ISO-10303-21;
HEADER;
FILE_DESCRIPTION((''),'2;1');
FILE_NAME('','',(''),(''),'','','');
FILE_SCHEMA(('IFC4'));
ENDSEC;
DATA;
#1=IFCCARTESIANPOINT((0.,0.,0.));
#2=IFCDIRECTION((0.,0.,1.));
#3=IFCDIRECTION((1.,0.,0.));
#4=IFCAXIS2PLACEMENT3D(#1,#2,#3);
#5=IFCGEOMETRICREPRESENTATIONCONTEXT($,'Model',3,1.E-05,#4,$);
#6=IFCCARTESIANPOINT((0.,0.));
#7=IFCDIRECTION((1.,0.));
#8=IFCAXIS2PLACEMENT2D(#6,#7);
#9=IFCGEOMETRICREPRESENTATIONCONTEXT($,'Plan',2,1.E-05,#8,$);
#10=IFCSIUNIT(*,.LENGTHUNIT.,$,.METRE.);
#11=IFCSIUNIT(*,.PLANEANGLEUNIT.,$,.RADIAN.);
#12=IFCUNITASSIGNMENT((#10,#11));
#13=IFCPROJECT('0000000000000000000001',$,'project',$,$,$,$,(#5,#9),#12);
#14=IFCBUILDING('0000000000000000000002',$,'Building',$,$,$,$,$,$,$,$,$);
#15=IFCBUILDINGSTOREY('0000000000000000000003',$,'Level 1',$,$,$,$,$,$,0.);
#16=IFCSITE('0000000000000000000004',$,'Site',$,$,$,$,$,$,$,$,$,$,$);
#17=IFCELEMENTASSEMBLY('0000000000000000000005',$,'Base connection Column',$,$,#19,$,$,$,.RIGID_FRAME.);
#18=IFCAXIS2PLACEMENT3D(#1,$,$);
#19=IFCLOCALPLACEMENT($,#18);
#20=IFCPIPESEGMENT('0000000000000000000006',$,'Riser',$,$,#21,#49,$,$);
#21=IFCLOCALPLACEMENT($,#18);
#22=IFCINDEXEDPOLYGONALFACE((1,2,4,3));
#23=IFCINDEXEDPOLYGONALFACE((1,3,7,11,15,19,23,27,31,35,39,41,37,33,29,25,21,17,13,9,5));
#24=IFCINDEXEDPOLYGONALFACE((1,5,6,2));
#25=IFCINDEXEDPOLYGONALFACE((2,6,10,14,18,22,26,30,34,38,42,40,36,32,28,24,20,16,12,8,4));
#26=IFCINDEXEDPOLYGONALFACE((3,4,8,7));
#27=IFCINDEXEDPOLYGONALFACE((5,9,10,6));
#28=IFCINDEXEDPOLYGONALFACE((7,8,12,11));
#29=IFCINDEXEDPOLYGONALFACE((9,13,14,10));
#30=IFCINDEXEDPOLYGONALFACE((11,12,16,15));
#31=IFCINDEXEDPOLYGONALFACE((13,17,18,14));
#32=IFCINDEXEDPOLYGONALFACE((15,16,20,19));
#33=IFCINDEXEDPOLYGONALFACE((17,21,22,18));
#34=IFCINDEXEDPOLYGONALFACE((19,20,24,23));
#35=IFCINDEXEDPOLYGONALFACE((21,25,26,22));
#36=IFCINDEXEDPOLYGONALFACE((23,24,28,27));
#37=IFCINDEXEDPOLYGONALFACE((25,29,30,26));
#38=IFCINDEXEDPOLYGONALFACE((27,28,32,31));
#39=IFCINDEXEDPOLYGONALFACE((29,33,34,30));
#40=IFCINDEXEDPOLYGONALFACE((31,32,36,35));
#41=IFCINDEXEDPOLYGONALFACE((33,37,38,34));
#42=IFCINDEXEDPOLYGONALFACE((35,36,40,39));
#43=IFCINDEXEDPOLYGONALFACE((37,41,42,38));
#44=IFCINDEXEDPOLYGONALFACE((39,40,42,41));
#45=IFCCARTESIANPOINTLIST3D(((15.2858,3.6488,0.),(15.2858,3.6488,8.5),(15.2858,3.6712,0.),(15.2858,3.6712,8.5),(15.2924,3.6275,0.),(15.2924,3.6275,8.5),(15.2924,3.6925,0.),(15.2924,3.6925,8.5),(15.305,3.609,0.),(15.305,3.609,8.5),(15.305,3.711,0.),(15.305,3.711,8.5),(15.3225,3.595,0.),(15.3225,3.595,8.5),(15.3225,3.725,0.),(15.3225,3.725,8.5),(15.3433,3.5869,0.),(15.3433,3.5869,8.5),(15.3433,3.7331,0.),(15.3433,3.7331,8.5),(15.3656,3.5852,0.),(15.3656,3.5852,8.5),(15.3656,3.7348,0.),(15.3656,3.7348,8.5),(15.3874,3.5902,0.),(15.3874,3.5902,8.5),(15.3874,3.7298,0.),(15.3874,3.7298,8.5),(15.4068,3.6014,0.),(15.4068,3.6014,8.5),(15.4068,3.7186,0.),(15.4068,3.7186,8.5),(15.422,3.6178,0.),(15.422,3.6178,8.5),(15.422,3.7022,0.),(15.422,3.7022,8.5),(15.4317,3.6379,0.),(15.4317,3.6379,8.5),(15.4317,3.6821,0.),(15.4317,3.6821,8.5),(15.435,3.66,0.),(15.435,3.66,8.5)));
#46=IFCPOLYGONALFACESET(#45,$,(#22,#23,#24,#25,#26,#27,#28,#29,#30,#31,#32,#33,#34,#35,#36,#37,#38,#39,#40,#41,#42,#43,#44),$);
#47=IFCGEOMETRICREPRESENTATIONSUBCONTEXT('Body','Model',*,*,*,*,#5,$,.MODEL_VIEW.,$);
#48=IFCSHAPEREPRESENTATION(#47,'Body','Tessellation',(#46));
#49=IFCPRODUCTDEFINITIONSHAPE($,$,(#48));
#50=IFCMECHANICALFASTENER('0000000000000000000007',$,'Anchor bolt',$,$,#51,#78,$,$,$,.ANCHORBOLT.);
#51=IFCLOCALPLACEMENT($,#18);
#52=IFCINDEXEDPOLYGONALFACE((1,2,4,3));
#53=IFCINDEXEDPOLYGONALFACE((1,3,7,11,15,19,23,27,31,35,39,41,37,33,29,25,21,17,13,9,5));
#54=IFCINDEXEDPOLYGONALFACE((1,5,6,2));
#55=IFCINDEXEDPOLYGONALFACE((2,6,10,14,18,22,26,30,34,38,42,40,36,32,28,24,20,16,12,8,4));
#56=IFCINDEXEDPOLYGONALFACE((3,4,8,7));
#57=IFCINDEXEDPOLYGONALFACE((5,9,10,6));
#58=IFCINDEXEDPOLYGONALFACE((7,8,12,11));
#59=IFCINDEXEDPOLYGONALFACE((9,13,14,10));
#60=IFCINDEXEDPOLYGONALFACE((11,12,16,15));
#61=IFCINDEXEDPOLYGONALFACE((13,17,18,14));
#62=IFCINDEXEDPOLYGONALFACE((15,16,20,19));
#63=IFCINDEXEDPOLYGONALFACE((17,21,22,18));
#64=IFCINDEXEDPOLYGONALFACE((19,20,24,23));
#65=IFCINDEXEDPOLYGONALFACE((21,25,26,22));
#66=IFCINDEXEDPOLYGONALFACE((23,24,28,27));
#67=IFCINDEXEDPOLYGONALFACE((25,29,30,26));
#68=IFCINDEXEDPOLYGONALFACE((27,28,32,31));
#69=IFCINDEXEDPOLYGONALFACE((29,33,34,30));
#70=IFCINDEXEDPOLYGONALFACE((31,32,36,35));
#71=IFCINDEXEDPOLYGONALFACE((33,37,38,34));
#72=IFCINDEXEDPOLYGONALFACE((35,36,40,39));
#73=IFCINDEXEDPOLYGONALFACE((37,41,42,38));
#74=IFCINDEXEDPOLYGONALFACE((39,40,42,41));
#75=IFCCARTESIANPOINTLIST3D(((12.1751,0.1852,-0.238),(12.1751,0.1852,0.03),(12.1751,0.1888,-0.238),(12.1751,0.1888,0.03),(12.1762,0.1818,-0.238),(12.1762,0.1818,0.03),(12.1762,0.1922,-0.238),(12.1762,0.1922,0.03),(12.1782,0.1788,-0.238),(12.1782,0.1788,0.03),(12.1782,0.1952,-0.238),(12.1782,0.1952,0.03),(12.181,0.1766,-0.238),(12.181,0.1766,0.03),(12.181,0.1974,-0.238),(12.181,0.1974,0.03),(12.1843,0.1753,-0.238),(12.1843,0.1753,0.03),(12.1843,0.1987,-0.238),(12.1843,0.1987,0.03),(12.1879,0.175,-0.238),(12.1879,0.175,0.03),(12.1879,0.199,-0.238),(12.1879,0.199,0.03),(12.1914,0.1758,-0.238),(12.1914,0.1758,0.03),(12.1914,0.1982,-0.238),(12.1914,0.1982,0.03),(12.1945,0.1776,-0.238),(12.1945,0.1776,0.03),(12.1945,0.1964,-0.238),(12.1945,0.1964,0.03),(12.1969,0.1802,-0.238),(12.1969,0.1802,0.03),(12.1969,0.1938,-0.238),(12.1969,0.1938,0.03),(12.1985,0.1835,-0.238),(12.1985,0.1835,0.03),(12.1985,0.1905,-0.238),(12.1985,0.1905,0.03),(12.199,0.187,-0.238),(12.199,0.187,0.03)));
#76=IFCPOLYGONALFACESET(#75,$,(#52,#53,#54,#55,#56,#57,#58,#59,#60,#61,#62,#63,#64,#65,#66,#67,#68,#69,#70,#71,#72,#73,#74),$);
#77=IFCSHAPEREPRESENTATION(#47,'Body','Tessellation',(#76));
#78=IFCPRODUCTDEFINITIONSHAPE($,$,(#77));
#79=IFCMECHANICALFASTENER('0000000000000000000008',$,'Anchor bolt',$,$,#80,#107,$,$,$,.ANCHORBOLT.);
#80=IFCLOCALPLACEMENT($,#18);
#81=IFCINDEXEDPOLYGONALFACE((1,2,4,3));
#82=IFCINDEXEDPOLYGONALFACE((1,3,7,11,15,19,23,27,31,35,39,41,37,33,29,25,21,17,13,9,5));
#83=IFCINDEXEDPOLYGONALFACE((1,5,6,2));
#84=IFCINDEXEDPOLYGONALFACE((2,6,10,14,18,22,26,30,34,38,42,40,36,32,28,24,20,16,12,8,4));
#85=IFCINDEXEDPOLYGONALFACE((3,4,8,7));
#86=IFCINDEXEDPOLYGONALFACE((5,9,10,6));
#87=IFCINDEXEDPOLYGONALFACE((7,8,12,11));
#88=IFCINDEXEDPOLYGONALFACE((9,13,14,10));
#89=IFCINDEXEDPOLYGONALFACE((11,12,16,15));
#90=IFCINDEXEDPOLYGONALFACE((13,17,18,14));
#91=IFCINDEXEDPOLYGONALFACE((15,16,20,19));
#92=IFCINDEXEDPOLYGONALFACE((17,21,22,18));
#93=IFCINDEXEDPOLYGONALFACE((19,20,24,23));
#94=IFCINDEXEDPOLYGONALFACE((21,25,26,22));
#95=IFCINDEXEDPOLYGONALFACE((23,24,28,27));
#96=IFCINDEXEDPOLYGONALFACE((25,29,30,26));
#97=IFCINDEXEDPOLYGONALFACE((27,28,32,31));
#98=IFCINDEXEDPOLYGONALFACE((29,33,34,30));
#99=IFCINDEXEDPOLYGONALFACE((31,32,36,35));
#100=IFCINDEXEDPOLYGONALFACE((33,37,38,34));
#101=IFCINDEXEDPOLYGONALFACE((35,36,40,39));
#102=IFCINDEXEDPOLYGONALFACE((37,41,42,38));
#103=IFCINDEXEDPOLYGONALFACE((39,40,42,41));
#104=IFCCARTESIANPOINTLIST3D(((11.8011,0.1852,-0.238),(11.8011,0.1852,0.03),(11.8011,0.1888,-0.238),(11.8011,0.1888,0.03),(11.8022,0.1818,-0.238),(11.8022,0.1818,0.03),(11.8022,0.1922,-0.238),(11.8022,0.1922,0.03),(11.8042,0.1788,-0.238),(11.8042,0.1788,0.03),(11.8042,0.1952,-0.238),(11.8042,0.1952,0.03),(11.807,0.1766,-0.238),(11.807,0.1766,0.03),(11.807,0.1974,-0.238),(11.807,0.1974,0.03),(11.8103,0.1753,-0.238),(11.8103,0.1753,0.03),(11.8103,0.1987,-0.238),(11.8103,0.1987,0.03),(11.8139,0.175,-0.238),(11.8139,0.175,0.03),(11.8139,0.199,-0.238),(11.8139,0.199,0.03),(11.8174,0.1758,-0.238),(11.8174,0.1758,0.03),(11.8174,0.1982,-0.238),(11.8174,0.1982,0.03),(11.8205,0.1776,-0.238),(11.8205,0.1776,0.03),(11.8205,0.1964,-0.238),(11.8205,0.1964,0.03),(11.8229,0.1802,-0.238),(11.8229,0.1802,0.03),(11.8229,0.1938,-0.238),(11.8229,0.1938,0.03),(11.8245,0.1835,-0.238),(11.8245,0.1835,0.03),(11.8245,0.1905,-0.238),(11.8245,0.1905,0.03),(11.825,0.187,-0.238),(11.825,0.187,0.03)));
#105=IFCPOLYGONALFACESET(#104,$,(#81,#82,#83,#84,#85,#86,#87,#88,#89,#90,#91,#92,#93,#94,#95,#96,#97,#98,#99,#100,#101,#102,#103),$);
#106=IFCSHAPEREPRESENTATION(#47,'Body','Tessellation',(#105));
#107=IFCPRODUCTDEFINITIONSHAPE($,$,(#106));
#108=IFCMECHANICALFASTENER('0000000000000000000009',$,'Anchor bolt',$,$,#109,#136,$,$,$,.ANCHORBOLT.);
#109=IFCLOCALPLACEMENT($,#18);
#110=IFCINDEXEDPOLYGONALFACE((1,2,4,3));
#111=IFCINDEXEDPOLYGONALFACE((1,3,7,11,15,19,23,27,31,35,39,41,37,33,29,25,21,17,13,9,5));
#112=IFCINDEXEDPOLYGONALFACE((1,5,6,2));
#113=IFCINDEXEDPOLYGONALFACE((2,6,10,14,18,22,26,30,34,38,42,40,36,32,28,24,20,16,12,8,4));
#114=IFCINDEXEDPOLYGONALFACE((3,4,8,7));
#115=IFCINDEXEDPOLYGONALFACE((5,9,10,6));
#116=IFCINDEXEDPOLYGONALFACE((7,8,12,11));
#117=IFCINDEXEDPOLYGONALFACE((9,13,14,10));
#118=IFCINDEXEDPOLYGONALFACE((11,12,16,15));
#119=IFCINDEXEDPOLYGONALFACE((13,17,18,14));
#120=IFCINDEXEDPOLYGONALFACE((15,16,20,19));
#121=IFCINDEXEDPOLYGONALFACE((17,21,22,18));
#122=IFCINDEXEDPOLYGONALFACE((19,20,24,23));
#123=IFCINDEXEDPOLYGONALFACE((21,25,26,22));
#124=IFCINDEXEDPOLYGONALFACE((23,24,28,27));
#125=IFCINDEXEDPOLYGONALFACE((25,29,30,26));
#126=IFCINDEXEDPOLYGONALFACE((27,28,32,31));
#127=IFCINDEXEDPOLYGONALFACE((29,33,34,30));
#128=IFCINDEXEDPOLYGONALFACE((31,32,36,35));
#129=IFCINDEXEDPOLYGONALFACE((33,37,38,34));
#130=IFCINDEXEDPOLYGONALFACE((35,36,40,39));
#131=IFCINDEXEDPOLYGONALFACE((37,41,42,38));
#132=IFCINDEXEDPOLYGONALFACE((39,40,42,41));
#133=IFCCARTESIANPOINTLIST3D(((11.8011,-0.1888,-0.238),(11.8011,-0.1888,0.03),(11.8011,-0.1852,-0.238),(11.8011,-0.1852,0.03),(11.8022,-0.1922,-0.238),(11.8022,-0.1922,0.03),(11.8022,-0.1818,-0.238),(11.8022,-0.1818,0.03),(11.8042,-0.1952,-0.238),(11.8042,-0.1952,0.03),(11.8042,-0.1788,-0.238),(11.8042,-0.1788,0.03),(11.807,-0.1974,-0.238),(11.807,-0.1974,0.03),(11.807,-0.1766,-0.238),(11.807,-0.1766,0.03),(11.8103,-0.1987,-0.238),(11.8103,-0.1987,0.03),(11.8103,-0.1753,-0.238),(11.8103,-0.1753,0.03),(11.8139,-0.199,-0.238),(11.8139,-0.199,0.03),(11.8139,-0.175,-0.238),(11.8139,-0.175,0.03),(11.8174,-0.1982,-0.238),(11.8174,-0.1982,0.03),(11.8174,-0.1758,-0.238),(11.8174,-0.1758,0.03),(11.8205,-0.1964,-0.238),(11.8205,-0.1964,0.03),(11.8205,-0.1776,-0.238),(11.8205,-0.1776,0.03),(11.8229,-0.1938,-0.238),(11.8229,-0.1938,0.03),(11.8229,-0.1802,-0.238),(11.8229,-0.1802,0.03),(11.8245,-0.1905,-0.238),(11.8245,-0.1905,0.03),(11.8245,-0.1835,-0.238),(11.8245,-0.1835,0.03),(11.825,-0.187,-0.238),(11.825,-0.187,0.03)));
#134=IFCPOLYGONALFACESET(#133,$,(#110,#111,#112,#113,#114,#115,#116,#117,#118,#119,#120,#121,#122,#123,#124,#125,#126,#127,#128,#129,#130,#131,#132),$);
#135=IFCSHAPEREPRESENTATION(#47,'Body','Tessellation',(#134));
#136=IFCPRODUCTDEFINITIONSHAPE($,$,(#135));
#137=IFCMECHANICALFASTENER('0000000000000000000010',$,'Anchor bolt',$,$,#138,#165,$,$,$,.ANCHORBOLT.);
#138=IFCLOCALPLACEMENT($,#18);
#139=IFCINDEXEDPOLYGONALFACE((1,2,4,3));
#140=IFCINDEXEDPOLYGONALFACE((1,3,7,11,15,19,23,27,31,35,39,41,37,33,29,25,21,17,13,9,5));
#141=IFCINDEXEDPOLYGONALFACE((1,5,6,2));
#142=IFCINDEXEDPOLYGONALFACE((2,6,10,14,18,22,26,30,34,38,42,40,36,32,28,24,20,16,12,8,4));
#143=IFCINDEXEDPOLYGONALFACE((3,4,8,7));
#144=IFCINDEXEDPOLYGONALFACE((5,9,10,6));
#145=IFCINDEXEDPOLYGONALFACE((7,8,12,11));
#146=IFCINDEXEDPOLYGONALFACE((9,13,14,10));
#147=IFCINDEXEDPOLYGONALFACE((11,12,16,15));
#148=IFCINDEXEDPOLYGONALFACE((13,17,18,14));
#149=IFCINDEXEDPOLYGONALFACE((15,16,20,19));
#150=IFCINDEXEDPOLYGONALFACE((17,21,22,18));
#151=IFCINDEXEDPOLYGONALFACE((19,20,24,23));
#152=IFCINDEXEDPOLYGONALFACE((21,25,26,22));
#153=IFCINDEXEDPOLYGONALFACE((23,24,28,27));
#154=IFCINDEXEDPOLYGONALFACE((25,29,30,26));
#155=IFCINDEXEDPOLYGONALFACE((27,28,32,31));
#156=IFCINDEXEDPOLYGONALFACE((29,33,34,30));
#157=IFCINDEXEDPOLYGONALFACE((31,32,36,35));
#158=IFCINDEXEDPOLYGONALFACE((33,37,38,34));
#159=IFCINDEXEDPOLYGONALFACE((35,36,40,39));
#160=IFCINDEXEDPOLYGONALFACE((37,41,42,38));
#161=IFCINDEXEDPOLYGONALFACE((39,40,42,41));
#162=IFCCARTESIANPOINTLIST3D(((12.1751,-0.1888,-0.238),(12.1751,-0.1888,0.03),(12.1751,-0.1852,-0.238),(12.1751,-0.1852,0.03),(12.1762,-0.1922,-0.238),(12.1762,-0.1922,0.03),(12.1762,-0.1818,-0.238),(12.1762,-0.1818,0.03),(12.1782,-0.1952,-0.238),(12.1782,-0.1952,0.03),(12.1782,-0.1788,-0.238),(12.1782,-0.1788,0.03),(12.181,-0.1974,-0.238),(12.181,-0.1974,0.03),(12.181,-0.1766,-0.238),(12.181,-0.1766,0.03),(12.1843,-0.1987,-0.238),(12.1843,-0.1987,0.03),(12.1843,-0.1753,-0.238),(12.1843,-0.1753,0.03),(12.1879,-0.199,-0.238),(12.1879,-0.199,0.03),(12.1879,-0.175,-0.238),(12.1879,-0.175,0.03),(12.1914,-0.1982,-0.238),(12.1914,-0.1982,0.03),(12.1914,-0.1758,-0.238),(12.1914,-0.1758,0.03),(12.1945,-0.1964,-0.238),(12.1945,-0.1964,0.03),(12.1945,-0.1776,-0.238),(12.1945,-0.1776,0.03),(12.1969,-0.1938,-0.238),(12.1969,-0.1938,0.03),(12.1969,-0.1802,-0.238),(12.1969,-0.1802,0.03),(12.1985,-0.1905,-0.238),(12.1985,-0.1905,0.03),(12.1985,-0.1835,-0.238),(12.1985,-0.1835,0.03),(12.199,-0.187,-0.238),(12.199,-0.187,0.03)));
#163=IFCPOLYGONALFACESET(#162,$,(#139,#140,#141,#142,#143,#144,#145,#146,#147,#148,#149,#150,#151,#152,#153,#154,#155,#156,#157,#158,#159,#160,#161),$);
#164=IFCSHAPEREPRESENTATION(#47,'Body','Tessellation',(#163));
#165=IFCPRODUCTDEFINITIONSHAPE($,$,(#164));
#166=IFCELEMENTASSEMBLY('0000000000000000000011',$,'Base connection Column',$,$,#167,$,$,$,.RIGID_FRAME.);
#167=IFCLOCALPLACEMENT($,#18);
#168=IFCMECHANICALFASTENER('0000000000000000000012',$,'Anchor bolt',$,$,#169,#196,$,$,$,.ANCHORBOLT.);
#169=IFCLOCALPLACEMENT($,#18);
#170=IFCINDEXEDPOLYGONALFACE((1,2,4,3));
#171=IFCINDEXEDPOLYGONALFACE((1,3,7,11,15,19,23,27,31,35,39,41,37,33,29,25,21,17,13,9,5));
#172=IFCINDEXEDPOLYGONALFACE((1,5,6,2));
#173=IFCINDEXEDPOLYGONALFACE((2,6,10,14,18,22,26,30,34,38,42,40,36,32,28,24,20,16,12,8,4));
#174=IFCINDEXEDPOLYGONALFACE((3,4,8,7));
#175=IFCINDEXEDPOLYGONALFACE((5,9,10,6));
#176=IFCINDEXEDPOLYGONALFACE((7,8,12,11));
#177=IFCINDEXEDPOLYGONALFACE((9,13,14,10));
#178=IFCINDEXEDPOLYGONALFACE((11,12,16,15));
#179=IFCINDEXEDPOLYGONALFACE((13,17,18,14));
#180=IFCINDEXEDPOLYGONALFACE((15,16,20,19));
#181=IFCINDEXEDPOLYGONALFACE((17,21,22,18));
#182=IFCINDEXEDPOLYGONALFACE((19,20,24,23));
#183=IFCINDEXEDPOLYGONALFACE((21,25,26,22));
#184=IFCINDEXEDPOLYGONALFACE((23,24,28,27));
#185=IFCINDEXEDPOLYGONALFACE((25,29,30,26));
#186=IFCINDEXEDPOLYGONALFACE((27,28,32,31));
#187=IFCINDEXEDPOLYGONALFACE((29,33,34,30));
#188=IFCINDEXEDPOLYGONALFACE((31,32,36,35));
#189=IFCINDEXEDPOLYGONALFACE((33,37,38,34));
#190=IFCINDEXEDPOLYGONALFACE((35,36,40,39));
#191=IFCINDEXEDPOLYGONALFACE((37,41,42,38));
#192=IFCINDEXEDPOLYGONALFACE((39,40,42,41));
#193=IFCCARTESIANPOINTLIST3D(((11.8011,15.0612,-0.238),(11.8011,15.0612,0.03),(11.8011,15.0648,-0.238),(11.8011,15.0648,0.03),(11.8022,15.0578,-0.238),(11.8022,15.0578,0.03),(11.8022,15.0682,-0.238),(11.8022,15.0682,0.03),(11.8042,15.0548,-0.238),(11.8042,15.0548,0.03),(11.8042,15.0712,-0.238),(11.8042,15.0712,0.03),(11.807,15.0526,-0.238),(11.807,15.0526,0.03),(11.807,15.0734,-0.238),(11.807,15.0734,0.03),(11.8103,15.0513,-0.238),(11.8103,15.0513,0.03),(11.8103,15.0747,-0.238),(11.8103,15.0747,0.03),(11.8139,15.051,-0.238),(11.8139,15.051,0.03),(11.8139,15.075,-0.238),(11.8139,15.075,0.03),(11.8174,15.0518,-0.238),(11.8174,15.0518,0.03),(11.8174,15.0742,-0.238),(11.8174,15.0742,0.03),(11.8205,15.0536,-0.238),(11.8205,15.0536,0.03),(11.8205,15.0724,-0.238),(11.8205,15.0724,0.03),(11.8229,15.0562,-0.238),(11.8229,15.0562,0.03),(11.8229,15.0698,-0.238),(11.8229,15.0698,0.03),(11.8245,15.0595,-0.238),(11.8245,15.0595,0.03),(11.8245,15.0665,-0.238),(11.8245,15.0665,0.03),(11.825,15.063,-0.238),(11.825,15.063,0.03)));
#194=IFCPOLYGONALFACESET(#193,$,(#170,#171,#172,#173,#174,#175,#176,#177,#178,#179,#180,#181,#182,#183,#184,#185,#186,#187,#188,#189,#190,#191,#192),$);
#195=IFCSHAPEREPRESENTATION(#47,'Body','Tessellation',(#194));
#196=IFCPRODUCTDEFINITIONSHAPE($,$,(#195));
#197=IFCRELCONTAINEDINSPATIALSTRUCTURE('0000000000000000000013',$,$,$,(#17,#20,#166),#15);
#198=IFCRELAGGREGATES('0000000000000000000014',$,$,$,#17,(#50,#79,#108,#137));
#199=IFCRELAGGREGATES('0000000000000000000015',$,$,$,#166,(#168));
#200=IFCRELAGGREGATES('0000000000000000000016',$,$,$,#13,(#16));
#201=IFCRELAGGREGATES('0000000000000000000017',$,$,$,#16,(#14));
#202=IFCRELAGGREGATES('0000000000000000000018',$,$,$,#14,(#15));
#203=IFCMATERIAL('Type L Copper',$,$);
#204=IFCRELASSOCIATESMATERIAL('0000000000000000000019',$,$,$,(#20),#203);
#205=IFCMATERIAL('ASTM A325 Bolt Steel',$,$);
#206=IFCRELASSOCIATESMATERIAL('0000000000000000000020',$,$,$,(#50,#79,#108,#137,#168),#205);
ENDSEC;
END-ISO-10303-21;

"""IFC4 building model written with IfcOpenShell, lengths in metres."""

from ifc_helpers import new_model, si_unit, frame, origin_with_axes, origin_2d, origin_2d_with_axis, place, context, subcontext, project, spatial, circle, extrude, material, element, aggregate, save


model = new_model("IFC4")

# Units and contexts
model_context = context("Model", 3, precision=1e-05, world=origin_with_axes())
plan_context = context("Plan", 2, precision=1e-05, world=origin_2d_with_axis())
body_context = subcontext(model_context, "Body", "Model", "MODEL_VIEW")
ifc_project = project(units=[si_unit("LENGTHUNIT", "METRE"), si_unit("PLANEANGLEUNIT", "RADIAN")], contexts=[model_context, plan_context])

# Site, building, storey
site = spatial("IfcSite", under=ifc_project, Name="Site")
building = spatial("IfcBuilding", under=site, Name="Building")
storey = spatial("IfcBuildingStorey", under=building, Name="Level 1", Elevation=0.0)

# Element assembly
assembly_1 = element("IfcElementAssembly", 1, inside=storey, Name="Base connection Column", PredefinedType="RIGID_FRAME")

# Pipe segment
ifc_material_1 = material(Name="Type L Copper")
for number, where, z_axis, x_axis, name in (
    (2, (15.36, 3.66, 0.0), (0.0, 0.0, 1.0), (1.0, 0.0, 0.0), "Riser"),
):
    element("IfcPipeSegment", number, at=place(None, frame(where, z_axis=z_axis, x_axis=x_axis)), inside=storey, material=ifc_material_1, Name=name, context=body_context, shape_type="SweptSolid", body=[
        extrude(circle(Radius=0.075), origin_with_axes(), (0.0, 0.0, 1.0), 8.5),
    ])

# Mechanical fasteners
ifc_material_2 = material(Name="ASTM A325 Bolt Steel")
mechanical_fastener_1_placement = place(None, frame((12.187, 0.187, -0.238), z_axis=(0.0, 0.0, 1.0), x_axis=(1.0, 0.0, 0.0)))
mechanical_fastener_1 = element("IfcMechanicalFastener", 3, at=mechanical_fastener_1_placement, material=ifc_material_2, Name="Anchor bolt", PredefinedType="ANCHORBOLT", context=body_context, shape_type="SweptSolid", body=[
    extrude(circle(Radius=0.012, at=origin_2d()), origin_with_axes(), (0.0, 0.0, 1.0), 0.268),
])
mechanical_fastener_2_placement = place(None, frame((11.813, 0.187, -0.238), z_axis=(0.0, 0.0, 1.0), x_axis=(1.0, 0.0, 0.0)))
mechanical_fastener_2 = element("IfcMechanicalFastener", 4, at=mechanical_fastener_2_placement, material=ifc_material_2, Name="Anchor bolt", PredefinedType="ANCHORBOLT", context=body_context, shape_type="SweptSolid", body=[
    extrude(circle(Radius=0.012, at=origin_2d()), origin_with_axes(), (0.0, 0.0, 1.0), 0.268),
])
mechanical_fastener_3_placement = place(None, frame((11.813, -0.187, -0.238), z_axis=(0.0, 0.0, 1.0), x_axis=(1.0, 0.0, 0.0)))
mechanical_fastener_3 = element("IfcMechanicalFastener", 5, at=mechanical_fastener_3_placement, material=ifc_material_2, Name="Anchor bolt", PredefinedType="ANCHORBOLT", context=body_context, shape_type="SweptSolid", body=[
    extrude(circle(Radius=0.012, at=origin_2d()), origin_with_axes(), (0.0, 0.0, 1.0), 0.268),
])
mechanical_fastener_4_placement = place(None, frame((12.187, -0.187, -0.238), z_axis=(0.0, 0.0, 1.0), x_axis=(1.0, 0.0, 0.0)))
mechanical_fastener_4 = element("IfcMechanicalFastener", 6, at=mechanical_fastener_4_placement, material=ifc_material_2, Name="Anchor bolt", PredefinedType="ANCHORBOLT", context=body_context, shape_type="SweptSolid", body=[
    extrude(circle(Radius=0.012, at=origin_2d()), origin_with_axes(), (0.0, 0.0, 1.0), 0.268),
])
aggregate(assembly_1, [mechanical_fastener_1, mechanical_fastener_2, mechanical_fastener_3, mechanical_fastener_4])

# Element assembly, mechanical fastener
assembly_2 = element("IfcElementAssembly", 7, inside=storey, Name="Base connection Column", PredefinedType="RIGID_FRAME")
mechanical_fastener_5_placement = place(None, frame((11.813, 15.063, -0.238), z_axis=(0.0, 0.0, 1.0), x_axis=(1.0, 0.0, 0.0)))
mechanical_fastener_5 = element("IfcMechanicalFastener", 8, at=mechanical_fastener_5_placement, material=ifc_material_2, Name="Anchor bolt", PredefinedType="ANCHORBOLT", context=body_context, shape_type="SweptSolid", body=[
    extrude(circle(Radius=0.012, at=origin_2d()), origin_with_axes(), (0.0, 0.0, 1.0), 0.268),
])
aggregate(assembly_2, [mechanical_fastener_5])

save(model, "model.ifc")
